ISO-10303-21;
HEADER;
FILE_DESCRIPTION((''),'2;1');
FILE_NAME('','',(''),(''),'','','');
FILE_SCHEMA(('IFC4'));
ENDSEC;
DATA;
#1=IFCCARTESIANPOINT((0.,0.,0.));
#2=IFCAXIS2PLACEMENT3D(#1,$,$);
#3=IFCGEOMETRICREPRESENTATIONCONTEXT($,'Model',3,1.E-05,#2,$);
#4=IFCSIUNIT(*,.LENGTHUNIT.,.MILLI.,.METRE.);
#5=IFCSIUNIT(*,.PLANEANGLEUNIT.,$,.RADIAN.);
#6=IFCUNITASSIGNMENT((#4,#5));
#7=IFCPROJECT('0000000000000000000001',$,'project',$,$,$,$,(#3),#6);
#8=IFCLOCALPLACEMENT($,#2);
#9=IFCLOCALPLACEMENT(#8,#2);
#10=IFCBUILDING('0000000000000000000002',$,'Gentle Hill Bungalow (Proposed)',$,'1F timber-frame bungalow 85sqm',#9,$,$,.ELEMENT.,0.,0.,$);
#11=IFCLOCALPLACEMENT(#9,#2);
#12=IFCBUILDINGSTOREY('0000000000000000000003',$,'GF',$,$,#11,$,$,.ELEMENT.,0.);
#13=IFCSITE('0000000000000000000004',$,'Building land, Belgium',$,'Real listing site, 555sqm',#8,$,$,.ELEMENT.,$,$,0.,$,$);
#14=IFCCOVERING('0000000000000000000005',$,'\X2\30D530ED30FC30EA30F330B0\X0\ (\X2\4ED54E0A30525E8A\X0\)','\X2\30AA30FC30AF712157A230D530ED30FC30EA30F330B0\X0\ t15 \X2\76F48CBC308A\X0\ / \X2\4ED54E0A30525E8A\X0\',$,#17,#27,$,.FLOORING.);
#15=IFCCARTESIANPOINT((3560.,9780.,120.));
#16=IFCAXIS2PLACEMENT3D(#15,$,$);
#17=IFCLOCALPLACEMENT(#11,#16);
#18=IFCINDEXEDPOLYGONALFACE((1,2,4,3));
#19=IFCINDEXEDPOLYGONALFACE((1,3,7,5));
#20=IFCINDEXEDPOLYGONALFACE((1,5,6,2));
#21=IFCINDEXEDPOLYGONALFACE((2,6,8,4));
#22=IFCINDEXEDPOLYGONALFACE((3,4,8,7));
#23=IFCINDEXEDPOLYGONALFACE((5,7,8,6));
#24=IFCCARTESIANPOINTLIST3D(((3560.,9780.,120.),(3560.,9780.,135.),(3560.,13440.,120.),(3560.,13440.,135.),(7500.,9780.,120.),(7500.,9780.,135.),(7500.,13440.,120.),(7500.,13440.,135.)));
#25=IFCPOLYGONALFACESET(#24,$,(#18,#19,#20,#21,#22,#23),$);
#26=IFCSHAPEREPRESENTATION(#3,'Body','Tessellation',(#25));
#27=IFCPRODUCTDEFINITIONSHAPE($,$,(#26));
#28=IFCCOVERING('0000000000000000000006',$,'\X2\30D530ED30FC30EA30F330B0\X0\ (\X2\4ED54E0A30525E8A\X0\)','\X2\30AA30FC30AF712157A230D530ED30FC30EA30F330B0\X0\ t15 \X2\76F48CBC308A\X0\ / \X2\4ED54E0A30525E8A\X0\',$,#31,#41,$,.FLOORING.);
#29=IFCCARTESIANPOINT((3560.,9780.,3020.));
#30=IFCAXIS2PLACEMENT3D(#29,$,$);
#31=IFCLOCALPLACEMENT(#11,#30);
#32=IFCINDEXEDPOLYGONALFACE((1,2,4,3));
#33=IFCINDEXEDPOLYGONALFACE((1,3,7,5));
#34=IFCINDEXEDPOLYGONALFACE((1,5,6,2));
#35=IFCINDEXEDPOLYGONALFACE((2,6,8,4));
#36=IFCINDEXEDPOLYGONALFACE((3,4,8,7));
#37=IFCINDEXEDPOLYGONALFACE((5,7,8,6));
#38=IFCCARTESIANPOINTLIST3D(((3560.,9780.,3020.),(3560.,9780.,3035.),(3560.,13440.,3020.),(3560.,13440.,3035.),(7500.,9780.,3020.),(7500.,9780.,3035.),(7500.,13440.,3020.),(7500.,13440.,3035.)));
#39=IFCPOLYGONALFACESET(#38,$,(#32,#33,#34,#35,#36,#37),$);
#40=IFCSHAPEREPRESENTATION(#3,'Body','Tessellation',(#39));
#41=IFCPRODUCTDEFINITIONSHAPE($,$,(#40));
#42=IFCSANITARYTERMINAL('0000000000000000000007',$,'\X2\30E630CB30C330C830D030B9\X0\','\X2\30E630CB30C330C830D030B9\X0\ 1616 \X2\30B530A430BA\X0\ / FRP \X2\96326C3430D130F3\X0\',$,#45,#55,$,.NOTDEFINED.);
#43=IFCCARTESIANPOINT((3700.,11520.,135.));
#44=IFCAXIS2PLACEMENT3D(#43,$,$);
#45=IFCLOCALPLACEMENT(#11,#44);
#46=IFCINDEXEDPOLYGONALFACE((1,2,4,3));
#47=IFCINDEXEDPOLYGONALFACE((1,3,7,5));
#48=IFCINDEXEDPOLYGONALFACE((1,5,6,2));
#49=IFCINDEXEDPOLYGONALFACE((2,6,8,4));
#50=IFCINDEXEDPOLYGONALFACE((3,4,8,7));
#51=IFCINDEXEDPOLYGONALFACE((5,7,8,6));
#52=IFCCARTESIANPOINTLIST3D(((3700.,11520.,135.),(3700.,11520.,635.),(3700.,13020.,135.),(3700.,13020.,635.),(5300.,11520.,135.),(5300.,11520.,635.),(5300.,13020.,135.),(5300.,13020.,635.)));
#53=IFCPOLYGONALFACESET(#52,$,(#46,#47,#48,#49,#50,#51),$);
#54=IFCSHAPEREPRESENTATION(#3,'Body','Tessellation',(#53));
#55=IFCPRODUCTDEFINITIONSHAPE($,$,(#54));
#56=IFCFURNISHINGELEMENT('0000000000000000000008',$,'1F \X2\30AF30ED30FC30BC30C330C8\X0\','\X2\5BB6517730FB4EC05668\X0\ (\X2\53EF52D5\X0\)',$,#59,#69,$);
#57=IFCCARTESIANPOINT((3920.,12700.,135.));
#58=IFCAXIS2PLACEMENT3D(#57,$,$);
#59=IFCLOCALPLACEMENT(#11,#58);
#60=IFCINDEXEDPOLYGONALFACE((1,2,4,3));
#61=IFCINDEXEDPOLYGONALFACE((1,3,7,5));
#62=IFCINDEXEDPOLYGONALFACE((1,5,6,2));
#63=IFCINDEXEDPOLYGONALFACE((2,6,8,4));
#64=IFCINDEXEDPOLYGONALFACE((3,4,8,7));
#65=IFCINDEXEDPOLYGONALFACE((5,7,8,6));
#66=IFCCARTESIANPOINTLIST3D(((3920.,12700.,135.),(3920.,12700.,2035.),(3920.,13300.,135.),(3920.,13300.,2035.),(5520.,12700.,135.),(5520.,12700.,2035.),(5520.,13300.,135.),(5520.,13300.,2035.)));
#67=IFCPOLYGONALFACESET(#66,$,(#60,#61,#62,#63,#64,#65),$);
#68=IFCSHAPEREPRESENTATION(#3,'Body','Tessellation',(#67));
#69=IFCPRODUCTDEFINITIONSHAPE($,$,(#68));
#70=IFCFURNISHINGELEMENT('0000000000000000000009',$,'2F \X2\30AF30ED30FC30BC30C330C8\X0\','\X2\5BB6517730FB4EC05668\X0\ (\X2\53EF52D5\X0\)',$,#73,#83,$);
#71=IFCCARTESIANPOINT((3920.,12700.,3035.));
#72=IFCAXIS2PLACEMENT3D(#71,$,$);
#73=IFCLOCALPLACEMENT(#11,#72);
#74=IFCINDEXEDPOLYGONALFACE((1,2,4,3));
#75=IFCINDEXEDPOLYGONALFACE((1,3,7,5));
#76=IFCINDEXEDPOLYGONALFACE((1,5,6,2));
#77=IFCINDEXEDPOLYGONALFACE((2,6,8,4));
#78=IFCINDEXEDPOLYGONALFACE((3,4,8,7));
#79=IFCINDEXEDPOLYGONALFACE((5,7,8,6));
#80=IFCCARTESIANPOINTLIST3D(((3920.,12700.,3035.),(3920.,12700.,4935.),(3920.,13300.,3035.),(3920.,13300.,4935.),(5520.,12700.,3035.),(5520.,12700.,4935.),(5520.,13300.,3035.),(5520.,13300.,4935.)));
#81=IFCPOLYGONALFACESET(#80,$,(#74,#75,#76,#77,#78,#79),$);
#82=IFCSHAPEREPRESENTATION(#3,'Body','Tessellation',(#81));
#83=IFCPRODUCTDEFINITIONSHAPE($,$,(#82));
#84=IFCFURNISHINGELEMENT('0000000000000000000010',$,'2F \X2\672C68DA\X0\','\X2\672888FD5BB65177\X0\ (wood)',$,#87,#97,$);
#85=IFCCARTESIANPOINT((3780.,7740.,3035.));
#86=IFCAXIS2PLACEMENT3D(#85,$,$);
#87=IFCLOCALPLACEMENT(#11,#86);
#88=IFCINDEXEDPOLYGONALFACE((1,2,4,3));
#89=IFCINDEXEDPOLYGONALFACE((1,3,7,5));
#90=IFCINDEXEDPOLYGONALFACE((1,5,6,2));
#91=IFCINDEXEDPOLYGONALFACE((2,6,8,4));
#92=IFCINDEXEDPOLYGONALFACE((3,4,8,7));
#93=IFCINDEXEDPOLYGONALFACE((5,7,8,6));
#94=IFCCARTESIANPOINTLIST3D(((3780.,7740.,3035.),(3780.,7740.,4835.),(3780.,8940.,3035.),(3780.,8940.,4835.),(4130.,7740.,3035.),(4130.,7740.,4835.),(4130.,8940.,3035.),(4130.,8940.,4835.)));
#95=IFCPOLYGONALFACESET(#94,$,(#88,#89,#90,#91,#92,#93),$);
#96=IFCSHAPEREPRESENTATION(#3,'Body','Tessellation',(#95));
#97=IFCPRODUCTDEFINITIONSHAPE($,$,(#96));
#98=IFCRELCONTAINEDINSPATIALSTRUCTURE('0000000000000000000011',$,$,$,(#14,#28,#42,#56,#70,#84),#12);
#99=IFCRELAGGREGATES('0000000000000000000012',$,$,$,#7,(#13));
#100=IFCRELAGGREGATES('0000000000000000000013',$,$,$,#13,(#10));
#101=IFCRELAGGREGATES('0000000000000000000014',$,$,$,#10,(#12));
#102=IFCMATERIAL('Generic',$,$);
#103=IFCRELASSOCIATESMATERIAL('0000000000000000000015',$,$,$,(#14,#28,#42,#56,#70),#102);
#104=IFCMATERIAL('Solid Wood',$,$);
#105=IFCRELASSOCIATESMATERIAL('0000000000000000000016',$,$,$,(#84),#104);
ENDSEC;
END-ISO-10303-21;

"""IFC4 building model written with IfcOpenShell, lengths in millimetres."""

from ifc_helpers import new_model, si_unit, frame, frame_2d, origin, place, context, project, spatial, rectangle, extrude, material, element, save


model = new_model("IFC4")

# Units and contexts
model_context = context("Model", 3, precision=1e-05, world=origin())
ifc_project = project(units=[si_unit("LENGTHUNIT", "METRE", prefix="MILLI"), si_unit("PLANEANGLEUNIT", "RADIAN")], contexts=[model_context])

# Site, building, storey
site_placement = place(None, origin())
site = spatial("IfcSite", under=ifc_project, at=site_placement, Name="Building land, Belgium", ObjectType="Real listing site, 555sqm", CompositionType="ELEMENT", RefElevation=0.0)
building_placement = place(site_placement, origin())
building = spatial("IfcBuilding", under=site, at=building_placement, Name="Gentle Hill Bungalow (Proposed)", ObjectType="1F timber-frame bungalow 85sqm", CompositionType="ELEMENT", ElevationOfRefHeight=0.0, ElevationOfTerrain=0.0)
storey_placement = place(building_placement, origin())
storey = spatial("IfcBuildingStorey", under=building, at=storey_placement, Name="GF", CompositionType="ELEMENT", Elevation=0.0)

# Shared definitions
ifc_material_1 = material(Name="Solid Wood")

# Coverings
ifc_material_2 = material(Name="Generic")
covering_1_placement = place(storey_placement, frame((3560.0, 9780.0, 120.0)))
element("IfcCovering", 1, at=covering_1_placement, inside=storey, material=ifc_material_2, Name="フローリング (仕上げ床)", Description="オーク無垢フローリング t15 直貼り / 仕上げ床", PredefinedType="FLOORING", context=model_context, shape_type="SweptSolid", body=[
    extrude(rectangle(XDim=3940.0, YDim=3660.0, at=frame_2d((1970.0, 1830.0))), frame((3560.0, 9780.0, 120.0)), (0.0, 0.0, 1.0), 15.0),
])
covering_2_placement = place(storey_placement, frame((3560.0, 9780.0, 3020.0)))
element("IfcCovering", 2, at=covering_2_placement, inside=storey, material=ifc_material_2, Name="フローリング (仕上げ床)", Description="オーク無垢フローリング t15 直貼り / 仕上げ床", PredefinedType="FLOORING", context=model_context, shape_type="SweptSolid", body=[
    extrude(rectangle(XDim=3940.0, YDim=3660.0, at=frame_2d((1970.0, 1830.0))), frame((3560.0, 9780.0, 3020.0)), (0.0, 0.0, 1.0), 15.0),
])

# Sanitary terminal
sanitary_terminal_placement = place(storey_placement, frame((3700.0, 11520.0, 135.0)))
element("IfcSanitaryTerminal", 3, at=sanitary_terminal_placement, inside=storey, material=ifc_material_2, Name="ユニットバス", Description="ユニットバス 1616 サイズ / FRP 防水パン", PredefinedType="NOTDEFINED", context=model_context, shape_type="SweptSolid", body=[
    extrude(rectangle(XDim=1600.0, YDim=1500.0, at=frame_2d((800.0, 750.0))), frame((3700.0, 11520.0, 135.0)), (0.0, 0.0, 1.0), 500.0),
])

# Furnishing elements
furnishing_1_placement = place(storey_placement, frame((3920.0, 12700.0, 135.0)))
element("IfcFurnishingElement", 4, at=furnishing_1_placement, inside=storey, material=ifc_material_2, Name="1F クローゼット", Description="家具・什器 (可動)", context=model_context, shape_type="SweptSolid", body=[
    extrude(rectangle(XDim=1600.0, YDim=600.0, at=frame_2d((800.0, 300.0))), frame((3920.0, 12700.0, 135.0)), (0.0, 0.0, 1.0), 1900.0),
])
furnishing_2_placement = place(storey_placement, frame((3920.0, 12700.0, 3035.0)))
element("IfcFurnishingElement", 5, at=furnishing_2_placement, inside=storey, material=ifc_material_2, Name="2F クローゼット", Description="家具・什器 (可動)", context=model_context, shape_type="SweptSolid", body=[
    extrude(rectangle(XDim=1600.0, YDim=600.0, at=frame_2d((800.0, 300.0))), frame((3920.0, 12700.0, 3035.0)), (0.0, 0.0, 1.0), 1900.0),
])
furnishing_3_placement = place(storey_placement, frame((3780.0, 7740.0, 3035.0)))
element("IfcFurnishingElement", 6, at=furnishing_3_placement, inside=storey, material=ifc_material_1, Name="2F 本棚", Description="木製家具 (wood)", context=model_context, shape_type="SweptSolid", body=[
    extrude(rectangle(XDim=350.0, YDim=1200.0, at=frame_2d((175.0, 600.0))), frame((3780.0, 7740.0, 3035.0)), (0.0, 0.0, 1.0), 1800.0),
])

save(model, "model.ifc")
